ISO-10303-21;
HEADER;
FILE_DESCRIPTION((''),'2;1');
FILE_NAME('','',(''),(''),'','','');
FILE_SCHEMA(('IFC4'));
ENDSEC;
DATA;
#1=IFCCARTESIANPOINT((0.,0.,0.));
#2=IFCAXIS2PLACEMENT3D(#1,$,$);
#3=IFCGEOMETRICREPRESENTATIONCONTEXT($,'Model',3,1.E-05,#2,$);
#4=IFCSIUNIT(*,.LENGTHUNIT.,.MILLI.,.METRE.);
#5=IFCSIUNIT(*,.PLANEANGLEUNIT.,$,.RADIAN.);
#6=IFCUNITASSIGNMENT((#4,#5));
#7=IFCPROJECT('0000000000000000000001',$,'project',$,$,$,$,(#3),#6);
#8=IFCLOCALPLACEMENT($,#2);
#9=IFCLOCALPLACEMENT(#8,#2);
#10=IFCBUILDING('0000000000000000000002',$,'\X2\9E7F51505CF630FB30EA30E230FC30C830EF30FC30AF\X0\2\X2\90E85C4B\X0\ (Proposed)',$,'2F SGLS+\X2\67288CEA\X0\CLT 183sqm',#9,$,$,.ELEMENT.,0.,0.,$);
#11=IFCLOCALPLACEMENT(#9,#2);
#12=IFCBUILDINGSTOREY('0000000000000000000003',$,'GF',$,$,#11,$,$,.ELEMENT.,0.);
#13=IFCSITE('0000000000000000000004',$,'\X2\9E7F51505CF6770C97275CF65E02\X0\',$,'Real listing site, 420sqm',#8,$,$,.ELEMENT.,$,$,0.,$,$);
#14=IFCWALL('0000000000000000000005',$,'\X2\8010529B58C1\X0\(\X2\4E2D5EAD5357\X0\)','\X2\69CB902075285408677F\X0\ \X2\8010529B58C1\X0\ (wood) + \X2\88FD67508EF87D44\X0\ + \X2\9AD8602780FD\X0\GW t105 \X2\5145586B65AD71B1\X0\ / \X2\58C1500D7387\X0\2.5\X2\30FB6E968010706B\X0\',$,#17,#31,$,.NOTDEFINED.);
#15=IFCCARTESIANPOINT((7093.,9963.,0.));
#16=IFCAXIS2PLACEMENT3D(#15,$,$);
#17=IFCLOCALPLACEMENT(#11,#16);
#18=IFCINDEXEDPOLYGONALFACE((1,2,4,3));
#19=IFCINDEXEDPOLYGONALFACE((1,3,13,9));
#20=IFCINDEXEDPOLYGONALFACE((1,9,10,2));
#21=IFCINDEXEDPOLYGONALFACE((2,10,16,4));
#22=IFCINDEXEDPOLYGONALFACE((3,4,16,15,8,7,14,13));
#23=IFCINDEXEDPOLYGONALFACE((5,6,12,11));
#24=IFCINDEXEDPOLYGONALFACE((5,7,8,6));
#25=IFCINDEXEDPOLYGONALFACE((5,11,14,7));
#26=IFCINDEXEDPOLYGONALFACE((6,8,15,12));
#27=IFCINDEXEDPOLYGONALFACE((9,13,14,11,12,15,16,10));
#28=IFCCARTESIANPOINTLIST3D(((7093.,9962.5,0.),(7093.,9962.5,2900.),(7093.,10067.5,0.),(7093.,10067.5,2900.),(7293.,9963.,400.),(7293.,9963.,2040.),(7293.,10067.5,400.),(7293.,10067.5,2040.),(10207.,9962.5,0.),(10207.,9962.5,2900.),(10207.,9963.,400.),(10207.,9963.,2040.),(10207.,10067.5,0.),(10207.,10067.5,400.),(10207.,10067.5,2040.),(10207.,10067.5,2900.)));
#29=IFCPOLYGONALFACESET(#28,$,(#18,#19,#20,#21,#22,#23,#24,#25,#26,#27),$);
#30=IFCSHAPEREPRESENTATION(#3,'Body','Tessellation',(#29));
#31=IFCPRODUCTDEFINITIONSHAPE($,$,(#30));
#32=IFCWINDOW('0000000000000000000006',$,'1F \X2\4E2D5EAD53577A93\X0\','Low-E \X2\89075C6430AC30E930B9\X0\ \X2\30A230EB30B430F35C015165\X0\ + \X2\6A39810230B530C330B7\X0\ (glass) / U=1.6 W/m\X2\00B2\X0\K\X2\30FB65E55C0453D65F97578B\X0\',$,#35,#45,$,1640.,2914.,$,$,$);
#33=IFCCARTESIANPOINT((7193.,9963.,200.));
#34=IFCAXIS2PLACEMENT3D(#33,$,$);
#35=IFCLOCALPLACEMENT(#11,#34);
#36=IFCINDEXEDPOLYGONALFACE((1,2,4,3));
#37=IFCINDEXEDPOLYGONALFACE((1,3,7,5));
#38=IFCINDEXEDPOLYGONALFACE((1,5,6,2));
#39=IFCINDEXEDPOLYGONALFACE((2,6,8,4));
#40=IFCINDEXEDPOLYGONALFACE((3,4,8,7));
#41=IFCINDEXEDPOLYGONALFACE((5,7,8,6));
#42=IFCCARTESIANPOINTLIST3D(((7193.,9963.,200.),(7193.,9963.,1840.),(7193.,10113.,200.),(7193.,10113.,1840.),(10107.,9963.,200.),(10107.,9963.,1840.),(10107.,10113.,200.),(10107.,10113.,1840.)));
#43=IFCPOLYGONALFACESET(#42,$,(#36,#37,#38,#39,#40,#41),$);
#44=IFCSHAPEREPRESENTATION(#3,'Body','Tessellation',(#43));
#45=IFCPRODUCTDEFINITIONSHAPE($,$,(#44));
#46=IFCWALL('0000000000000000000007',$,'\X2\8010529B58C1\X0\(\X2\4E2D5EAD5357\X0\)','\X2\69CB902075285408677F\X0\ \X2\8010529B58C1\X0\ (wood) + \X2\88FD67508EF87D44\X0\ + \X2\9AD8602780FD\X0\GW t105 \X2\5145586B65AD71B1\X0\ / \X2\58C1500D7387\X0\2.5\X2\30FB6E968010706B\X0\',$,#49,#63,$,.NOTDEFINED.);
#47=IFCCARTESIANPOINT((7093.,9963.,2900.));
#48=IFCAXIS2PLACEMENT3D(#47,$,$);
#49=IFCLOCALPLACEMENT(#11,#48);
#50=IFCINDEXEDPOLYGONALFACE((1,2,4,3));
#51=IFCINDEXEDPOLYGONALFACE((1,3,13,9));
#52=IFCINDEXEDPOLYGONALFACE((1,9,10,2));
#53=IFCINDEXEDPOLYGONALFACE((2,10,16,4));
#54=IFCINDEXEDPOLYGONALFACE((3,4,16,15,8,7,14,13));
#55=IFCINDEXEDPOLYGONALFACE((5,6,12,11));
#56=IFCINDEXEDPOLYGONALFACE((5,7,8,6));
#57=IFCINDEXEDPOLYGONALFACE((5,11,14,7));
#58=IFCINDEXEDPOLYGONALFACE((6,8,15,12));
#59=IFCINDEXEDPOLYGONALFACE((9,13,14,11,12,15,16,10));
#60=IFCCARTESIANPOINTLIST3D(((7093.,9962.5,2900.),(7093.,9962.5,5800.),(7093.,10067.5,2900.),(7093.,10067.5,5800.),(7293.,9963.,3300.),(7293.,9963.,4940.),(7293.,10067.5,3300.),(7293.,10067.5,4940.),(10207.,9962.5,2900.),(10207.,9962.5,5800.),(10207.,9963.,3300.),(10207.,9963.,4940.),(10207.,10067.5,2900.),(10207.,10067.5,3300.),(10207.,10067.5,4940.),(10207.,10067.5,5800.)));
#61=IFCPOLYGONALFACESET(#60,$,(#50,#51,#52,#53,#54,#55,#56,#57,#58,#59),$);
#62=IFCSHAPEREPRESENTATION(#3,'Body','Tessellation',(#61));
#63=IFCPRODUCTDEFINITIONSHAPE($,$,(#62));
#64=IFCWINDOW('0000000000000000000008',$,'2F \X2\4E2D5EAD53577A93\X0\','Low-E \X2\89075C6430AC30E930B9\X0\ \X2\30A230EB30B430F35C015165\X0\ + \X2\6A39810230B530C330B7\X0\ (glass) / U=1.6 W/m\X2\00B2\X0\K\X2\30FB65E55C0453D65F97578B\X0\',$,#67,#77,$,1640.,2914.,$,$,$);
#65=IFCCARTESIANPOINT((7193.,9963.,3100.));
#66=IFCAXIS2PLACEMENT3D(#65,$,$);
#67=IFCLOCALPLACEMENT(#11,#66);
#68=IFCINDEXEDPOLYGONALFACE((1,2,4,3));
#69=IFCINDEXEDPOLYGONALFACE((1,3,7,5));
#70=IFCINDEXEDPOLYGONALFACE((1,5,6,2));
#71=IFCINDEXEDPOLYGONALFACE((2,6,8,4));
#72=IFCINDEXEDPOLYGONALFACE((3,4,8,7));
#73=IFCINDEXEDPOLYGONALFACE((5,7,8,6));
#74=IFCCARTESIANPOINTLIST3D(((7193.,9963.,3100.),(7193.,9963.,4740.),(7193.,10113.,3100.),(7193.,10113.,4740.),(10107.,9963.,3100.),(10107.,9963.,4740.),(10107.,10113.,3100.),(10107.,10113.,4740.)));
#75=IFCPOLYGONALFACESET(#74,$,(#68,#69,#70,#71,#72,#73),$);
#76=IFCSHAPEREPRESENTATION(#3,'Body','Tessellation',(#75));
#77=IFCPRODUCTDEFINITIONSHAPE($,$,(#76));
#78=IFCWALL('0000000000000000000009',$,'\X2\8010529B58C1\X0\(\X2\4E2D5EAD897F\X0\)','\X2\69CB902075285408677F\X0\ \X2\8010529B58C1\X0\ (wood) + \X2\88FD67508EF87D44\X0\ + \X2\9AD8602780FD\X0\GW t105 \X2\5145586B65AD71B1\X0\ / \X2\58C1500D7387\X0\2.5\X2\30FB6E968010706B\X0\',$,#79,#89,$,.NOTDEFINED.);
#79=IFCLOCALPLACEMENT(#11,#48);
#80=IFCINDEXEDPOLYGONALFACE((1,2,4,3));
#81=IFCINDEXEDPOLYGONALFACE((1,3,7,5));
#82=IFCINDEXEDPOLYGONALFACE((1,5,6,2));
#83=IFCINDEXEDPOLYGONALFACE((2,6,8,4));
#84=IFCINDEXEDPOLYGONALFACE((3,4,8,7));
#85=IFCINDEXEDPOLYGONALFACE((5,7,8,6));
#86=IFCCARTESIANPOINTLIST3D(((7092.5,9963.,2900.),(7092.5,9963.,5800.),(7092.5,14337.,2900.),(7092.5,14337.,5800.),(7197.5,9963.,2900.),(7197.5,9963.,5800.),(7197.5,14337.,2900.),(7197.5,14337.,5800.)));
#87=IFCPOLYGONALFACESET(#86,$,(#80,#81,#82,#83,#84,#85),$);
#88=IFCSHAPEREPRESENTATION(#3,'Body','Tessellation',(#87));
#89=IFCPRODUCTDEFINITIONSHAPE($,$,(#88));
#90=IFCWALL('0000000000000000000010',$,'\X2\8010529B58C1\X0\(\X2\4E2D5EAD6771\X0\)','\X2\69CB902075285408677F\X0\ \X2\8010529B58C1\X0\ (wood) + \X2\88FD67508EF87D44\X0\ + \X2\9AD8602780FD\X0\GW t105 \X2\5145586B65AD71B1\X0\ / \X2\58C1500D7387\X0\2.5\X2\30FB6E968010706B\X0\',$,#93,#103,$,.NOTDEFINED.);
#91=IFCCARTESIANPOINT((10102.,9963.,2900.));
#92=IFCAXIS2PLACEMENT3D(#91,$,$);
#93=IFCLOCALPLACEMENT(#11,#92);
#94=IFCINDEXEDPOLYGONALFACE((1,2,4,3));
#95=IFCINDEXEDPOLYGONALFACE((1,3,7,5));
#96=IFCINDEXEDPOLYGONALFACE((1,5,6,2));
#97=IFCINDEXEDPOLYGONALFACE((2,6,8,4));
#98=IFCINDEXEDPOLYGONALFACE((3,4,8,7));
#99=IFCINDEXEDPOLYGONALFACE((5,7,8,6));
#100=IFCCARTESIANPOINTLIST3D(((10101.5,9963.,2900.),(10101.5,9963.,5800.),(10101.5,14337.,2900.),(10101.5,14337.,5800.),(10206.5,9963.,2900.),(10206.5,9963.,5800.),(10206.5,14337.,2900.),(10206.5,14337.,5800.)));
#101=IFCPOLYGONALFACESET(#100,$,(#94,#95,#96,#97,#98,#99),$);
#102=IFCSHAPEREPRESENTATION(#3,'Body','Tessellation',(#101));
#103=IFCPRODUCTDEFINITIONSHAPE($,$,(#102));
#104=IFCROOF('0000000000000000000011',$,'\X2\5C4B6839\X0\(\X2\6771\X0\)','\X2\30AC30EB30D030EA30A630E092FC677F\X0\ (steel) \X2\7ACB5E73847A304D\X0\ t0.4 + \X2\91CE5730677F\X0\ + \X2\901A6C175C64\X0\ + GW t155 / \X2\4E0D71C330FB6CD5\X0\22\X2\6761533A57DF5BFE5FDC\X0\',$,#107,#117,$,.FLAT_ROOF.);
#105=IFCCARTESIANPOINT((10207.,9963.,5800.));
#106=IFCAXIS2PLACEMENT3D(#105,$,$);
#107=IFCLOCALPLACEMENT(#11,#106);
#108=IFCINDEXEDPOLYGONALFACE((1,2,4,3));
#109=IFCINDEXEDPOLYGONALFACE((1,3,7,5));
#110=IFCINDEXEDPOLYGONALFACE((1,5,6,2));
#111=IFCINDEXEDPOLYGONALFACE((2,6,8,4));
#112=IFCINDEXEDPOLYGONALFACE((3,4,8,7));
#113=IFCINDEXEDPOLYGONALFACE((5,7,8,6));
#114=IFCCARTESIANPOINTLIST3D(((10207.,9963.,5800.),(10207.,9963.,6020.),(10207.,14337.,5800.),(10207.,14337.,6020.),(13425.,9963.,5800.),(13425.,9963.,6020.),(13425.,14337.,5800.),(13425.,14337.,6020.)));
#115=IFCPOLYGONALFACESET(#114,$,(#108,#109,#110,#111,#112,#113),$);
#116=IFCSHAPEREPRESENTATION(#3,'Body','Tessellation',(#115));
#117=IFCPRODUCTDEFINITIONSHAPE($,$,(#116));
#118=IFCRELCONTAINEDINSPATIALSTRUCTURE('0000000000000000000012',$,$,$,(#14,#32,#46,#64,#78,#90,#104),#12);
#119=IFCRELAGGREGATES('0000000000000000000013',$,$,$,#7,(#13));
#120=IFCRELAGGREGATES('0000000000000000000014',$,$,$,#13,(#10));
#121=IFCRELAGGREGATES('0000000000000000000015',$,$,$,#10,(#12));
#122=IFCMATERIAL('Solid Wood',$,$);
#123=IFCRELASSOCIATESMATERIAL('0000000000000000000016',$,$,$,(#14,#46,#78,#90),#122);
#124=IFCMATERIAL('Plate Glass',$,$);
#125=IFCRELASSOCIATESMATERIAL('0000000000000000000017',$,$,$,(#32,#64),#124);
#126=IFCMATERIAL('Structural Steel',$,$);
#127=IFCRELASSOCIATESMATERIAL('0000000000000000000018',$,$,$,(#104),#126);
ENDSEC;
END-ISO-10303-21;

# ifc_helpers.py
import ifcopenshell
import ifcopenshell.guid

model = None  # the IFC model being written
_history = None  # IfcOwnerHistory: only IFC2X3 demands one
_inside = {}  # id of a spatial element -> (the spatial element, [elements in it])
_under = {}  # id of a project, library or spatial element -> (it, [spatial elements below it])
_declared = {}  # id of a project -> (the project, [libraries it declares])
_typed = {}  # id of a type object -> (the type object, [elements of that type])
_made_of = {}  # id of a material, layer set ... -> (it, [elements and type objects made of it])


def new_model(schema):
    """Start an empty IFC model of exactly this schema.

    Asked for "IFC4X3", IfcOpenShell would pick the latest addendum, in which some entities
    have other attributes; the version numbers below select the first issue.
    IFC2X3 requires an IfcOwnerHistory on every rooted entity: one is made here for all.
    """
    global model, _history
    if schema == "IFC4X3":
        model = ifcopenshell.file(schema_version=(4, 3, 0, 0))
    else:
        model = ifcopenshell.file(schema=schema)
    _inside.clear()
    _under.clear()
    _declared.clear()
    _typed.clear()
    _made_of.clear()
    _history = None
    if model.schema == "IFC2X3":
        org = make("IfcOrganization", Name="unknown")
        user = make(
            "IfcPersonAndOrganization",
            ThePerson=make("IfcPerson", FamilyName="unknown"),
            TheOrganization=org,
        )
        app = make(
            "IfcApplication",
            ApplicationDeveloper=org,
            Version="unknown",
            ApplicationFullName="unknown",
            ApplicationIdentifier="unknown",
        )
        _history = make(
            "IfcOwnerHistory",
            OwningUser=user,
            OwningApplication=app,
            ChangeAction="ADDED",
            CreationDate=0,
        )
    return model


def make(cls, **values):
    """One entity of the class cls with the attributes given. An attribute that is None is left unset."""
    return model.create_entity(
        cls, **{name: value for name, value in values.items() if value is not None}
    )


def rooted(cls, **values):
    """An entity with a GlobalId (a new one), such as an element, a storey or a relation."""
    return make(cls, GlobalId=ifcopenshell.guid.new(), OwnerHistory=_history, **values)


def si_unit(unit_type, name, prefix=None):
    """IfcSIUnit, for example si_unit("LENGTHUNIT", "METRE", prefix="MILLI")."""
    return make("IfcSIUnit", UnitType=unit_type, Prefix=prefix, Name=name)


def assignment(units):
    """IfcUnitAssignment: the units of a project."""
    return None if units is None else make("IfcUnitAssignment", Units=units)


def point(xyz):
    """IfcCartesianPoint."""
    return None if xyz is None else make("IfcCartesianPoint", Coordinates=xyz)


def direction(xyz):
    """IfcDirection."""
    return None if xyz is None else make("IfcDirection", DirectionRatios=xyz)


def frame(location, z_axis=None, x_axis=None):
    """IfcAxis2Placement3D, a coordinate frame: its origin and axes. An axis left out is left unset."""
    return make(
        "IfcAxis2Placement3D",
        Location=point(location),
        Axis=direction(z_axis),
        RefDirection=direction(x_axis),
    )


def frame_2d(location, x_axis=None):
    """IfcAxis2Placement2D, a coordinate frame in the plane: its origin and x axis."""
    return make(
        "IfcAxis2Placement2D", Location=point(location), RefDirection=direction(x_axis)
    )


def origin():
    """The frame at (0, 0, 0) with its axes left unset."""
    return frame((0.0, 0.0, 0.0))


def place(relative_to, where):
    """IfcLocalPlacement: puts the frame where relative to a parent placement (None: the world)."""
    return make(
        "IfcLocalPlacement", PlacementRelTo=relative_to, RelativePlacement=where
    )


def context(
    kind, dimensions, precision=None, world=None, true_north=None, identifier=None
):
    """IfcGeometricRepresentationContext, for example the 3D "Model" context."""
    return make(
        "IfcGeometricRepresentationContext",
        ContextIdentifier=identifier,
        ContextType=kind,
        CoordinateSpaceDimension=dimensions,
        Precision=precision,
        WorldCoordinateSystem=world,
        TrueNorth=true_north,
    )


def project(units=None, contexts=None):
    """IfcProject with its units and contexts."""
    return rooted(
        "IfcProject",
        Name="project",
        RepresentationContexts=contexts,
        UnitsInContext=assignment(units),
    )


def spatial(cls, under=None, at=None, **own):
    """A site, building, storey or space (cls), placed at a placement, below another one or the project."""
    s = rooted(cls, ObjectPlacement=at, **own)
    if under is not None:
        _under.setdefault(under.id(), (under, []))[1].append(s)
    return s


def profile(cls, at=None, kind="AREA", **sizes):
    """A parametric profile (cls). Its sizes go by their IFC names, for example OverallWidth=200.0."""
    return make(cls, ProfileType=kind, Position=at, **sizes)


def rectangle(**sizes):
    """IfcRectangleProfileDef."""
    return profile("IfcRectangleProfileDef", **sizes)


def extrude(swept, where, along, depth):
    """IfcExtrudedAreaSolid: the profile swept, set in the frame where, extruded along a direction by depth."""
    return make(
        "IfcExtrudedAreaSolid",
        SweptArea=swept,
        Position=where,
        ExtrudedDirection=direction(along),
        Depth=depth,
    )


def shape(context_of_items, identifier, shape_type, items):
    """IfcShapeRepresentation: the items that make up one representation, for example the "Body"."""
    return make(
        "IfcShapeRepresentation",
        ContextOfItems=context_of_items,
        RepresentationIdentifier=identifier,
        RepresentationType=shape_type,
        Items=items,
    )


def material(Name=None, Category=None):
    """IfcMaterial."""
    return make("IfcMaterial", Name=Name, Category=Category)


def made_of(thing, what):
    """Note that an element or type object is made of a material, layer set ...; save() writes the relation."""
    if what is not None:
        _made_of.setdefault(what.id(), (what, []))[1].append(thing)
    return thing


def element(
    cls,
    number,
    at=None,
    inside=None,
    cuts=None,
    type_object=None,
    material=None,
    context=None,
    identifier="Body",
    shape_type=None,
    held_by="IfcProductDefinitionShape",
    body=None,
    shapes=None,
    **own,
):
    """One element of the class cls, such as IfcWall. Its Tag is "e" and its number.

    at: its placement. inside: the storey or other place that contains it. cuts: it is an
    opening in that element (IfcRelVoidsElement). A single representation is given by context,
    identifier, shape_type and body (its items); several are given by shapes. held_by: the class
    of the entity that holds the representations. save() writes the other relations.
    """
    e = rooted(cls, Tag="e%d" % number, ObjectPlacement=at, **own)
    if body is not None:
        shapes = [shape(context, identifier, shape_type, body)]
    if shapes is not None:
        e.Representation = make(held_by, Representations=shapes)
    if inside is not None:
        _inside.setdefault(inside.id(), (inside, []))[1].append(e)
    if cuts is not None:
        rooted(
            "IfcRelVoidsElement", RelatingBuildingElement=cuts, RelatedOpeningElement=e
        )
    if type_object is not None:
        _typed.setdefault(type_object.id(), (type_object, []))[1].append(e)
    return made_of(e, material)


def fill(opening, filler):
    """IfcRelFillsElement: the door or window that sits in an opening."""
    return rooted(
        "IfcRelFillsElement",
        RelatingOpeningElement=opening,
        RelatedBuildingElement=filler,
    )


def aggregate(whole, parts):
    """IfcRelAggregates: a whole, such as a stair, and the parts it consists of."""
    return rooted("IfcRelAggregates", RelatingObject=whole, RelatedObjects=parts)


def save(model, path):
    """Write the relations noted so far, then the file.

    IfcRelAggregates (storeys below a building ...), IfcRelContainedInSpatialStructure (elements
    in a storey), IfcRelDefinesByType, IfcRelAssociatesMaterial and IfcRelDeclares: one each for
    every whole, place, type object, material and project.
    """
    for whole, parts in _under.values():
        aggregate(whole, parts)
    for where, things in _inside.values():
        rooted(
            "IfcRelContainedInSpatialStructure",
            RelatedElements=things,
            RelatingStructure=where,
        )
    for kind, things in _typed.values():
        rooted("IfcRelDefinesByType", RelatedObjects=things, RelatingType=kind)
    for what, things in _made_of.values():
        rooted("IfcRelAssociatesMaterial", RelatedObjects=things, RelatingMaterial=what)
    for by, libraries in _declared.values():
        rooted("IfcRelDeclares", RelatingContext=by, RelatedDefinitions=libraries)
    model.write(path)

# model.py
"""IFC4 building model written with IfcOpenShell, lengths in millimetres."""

from ifc_helpers import new_model, si_unit, frame, frame_2d, origin, place, context, project, spatial, rectangle, extrude, material, element, fill, save


model = new_model("IFC4")

# Units and contexts
model_context = context("Model", 3, precision=1e-05, world=origin())
ifc_project = project(units=[si_unit("LENGTHUNIT", "METRE", prefix="MILLI"), si_unit("PLANEANGLEUNIT", "RADIAN")], contexts=[model_context])

# Site, building, storey
site_placement = place(None, origin())
site = spatial("IfcSite", under=ifc_project, at=site_placement, Name="鹿児島県霧島市", ObjectType="Real listing site, 420sqm", CompositionType="ELEMENT", RefElevation=0.0)
building_placement = place(site_placement, origin())
building = spatial("IfcBuilding", under=site, at=building_placement, Name="鹿児島・リモートワーク2部屋 (Proposed)", ObjectType="2F SGLS+木質CLT 183sqm", CompositionType="ELEMENT", ElevationOfRefHeight=0.0, ElevationOfTerrain=0.0)
storey_placement = place(building_placement, origin())
storey = spatial("IfcBuildingStorey", under=building, at=storey_placement, Name="GF", CompositionType="ELEMENT", Elevation=0.0)

# Shared definitions
ifc_material_1 = material(Name="Solid Wood")

# Wall, opening, window
wall_1_placement = place(storey_placement, frame((7093.0, 9963.0, 0.0)))
wall_1 = element("IfcWall", 1, at=wall_1_placement, inside=storey, material=ifc_material_1, Name="耐力壁(中庭南)", Description="構造用合板 耐力壁 (wood) + 製材軸組 + 高性能GW t105 充填断熱 / 壁倍率2.5・準耐火", PredefinedType="NOTDEFINED", context=model_context, shape_type="SweptSolid", body=[
    extrude(rectangle(XDim=3114.0, YDim=105.0, at=frame_2d((1557.0, 52.0))), frame((7093.0, 9963.0, 0.0)), (0.0, 0.0, 1.0), 2900.0),
])
opening_1_placement = place(storey_placement, frame((7193.0, 9963.0, 200.0)))
opening_1 = element("IfcOpeningElement", 2, at=opening_1_placement, cuts=wall_1, PredefinedType="NOTDEFINED", context=model_context, shape_type="SweptSolid", body=[
    extrude(rectangle(XDim=2914.0, YDim=150.0, at=frame_2d((1457.0, 75.0))), frame((7193.0, 9963.0, 200.0)), (0.0, 0.0, 1.0), 1640.0),
])
ifc_material_2 = material(Name="Plate Glass")
window_1_placement = place(storey_placement, frame((7193.0, 9963.0, 200.0)))
window_1 = element("IfcWindow", 3, at=window_1_placement, inside=storey, material=ifc_material_2, Name="1F 中庭南窓", Description="Low-E 複層ガラス アルゴン封入 + 樹脂サッシ (glass) / U=1.6 W/m²K・日射取得型", OverallHeight=1640.0, OverallWidth=2914.0, context=model_context, shape_type="SweptSolid", body=[
    extrude(rectangle(XDim=2914.0, YDim=150.0, at=frame_2d((1457.0, 75.0))), frame((7193.0, 9963.0, 200.0)), (0.0, 0.0, 1.0), 1640.0),
])
fill(opening_1, window_1)

# Wall, opening, window
wall_2_placement = place(storey_placement, frame((7093.0, 9963.0, 2900.0)))
wall_2 = element("IfcWall", 4, at=wall_2_placement, inside=storey, material=ifc_material_1, Name="耐力壁(中庭南)", Description="構造用合板 耐力壁 (wood) + 製材軸組 + 高性能GW t105 充填断熱 / 壁倍率2.5・準耐火", PredefinedType="NOTDEFINED", context=model_context, shape_type="SweptSolid", body=[
    extrude(rectangle(XDim=3114.0, YDim=105.0, at=frame_2d((1557.0, 52.0))), frame((7093.0, 9963.0, 2900.0)), (0.0, 0.0, 1.0), 2900.0),
])
opening_2_placement = place(storey_placement, frame((7193.0, 9963.0, 3100.0)))
opening_2 = element("IfcOpeningElement", 5, at=opening_2_placement, cuts=wall_2, PredefinedType="NOTDEFINED", context=model_context, shape_type="SweptSolid", body=[
    extrude(rectangle(XDim=2914.0, YDim=150.0, at=frame_2d((1457.0, 75.0))), frame((7193.0, 9963.0, 3100.0)), (0.0, 0.0, 1.0), 1640.0),
])
window_2_placement = place(storey_placement, frame((7193.0, 9963.0, 3100.0)))
window_2 = element("IfcWindow", 6, at=window_2_placement, inside=storey, material=ifc_material_2, Name="2F 中庭南窓", Description="Low-E 複層ガラス アルゴン封入 + 樹脂サッシ (glass) / U=1.6 W/m²K・日射取得型", OverallHeight=1640.0, OverallWidth=2914.0, context=model_context, shape_type="SweptSolid", body=[
    extrude(rectangle(XDim=2914.0, YDim=150.0, at=frame_2d((1457.0, 75.0))), frame((7193.0, 9963.0, 3100.0)), (0.0, 0.0, 1.0), 1640.0),
])
fill(opening_2, window_2)

# Walls
wall_3_placement = place(storey_placement, frame((7093.0, 9963.0, 2900.0)))
element("IfcWall", 7, at=wall_3_placement, inside=storey, material=ifc_material_1, Name="耐力壁(中庭西)", Description="構造用合板 耐力壁 (wood) + 製材軸組 + 高性能GW t105 充填断熱 / 壁倍率2.5・準耐火", PredefinedType="NOTDEFINED", context=model_context, shape_type="SweptSolid", body=[
    extrude(rectangle(XDim=105.0, YDim=4374.0, at=frame_2d((52.0, 2187.0))), frame((7093.0, 9963.0, 2900.0)), (0.0, 0.0, 1.0), 2900.0),
])
wall_4_placement = place(storey_placement, frame((10102.0, 9963.0, 2900.0)))
element("IfcWall", 8, at=wall_4_placement, inside=storey, material=ifc_material_1, Name="耐力壁(中庭東)", Description="構造用合板 耐力壁 (wood) + 製材軸組 + 高性能GW t105 充填断熱 / 壁倍率2.5・準耐火", PredefinedType="NOTDEFINED", context=model_context, shape_type="SweptSolid", body=[
    extrude(rectangle(XDim=105.0, YDim=4374.0, at=frame_2d((52.0, 2187.0))), frame((10102.0, 9963.0, 2900.0)), (0.0, 0.0, 1.0), 2900.0),
])

# Roof
ifc_material_3 = material(Name="Structural Steel")
for number, where, name in (
    (9, (10207.0, 9963.0, 5800.0), "屋根(東)"),
):
    element("IfcRoof", number, at=place(storey_placement, frame(where)), inside=storey, material=ifc_material_3, Name=name, Description="ガルバリウム鋼板 (steel) 立平葺き t0.4 + 野地板 + 通気層 + GW t155 / 不燃・法22条区域対応", PredefinedType="FLAT_ROOF", context=model_context, shape_type="SweptSolid", body=[
        extrude(rectangle(XDim=3218.0, YDim=4374.0, at=frame_2d((1609.0, 2187.0))), frame((10207.0, 9963.0, 5800.0)), (0.0, 0.0, 1.0), 220.0),
    ])

save(model, "model.ifc")
